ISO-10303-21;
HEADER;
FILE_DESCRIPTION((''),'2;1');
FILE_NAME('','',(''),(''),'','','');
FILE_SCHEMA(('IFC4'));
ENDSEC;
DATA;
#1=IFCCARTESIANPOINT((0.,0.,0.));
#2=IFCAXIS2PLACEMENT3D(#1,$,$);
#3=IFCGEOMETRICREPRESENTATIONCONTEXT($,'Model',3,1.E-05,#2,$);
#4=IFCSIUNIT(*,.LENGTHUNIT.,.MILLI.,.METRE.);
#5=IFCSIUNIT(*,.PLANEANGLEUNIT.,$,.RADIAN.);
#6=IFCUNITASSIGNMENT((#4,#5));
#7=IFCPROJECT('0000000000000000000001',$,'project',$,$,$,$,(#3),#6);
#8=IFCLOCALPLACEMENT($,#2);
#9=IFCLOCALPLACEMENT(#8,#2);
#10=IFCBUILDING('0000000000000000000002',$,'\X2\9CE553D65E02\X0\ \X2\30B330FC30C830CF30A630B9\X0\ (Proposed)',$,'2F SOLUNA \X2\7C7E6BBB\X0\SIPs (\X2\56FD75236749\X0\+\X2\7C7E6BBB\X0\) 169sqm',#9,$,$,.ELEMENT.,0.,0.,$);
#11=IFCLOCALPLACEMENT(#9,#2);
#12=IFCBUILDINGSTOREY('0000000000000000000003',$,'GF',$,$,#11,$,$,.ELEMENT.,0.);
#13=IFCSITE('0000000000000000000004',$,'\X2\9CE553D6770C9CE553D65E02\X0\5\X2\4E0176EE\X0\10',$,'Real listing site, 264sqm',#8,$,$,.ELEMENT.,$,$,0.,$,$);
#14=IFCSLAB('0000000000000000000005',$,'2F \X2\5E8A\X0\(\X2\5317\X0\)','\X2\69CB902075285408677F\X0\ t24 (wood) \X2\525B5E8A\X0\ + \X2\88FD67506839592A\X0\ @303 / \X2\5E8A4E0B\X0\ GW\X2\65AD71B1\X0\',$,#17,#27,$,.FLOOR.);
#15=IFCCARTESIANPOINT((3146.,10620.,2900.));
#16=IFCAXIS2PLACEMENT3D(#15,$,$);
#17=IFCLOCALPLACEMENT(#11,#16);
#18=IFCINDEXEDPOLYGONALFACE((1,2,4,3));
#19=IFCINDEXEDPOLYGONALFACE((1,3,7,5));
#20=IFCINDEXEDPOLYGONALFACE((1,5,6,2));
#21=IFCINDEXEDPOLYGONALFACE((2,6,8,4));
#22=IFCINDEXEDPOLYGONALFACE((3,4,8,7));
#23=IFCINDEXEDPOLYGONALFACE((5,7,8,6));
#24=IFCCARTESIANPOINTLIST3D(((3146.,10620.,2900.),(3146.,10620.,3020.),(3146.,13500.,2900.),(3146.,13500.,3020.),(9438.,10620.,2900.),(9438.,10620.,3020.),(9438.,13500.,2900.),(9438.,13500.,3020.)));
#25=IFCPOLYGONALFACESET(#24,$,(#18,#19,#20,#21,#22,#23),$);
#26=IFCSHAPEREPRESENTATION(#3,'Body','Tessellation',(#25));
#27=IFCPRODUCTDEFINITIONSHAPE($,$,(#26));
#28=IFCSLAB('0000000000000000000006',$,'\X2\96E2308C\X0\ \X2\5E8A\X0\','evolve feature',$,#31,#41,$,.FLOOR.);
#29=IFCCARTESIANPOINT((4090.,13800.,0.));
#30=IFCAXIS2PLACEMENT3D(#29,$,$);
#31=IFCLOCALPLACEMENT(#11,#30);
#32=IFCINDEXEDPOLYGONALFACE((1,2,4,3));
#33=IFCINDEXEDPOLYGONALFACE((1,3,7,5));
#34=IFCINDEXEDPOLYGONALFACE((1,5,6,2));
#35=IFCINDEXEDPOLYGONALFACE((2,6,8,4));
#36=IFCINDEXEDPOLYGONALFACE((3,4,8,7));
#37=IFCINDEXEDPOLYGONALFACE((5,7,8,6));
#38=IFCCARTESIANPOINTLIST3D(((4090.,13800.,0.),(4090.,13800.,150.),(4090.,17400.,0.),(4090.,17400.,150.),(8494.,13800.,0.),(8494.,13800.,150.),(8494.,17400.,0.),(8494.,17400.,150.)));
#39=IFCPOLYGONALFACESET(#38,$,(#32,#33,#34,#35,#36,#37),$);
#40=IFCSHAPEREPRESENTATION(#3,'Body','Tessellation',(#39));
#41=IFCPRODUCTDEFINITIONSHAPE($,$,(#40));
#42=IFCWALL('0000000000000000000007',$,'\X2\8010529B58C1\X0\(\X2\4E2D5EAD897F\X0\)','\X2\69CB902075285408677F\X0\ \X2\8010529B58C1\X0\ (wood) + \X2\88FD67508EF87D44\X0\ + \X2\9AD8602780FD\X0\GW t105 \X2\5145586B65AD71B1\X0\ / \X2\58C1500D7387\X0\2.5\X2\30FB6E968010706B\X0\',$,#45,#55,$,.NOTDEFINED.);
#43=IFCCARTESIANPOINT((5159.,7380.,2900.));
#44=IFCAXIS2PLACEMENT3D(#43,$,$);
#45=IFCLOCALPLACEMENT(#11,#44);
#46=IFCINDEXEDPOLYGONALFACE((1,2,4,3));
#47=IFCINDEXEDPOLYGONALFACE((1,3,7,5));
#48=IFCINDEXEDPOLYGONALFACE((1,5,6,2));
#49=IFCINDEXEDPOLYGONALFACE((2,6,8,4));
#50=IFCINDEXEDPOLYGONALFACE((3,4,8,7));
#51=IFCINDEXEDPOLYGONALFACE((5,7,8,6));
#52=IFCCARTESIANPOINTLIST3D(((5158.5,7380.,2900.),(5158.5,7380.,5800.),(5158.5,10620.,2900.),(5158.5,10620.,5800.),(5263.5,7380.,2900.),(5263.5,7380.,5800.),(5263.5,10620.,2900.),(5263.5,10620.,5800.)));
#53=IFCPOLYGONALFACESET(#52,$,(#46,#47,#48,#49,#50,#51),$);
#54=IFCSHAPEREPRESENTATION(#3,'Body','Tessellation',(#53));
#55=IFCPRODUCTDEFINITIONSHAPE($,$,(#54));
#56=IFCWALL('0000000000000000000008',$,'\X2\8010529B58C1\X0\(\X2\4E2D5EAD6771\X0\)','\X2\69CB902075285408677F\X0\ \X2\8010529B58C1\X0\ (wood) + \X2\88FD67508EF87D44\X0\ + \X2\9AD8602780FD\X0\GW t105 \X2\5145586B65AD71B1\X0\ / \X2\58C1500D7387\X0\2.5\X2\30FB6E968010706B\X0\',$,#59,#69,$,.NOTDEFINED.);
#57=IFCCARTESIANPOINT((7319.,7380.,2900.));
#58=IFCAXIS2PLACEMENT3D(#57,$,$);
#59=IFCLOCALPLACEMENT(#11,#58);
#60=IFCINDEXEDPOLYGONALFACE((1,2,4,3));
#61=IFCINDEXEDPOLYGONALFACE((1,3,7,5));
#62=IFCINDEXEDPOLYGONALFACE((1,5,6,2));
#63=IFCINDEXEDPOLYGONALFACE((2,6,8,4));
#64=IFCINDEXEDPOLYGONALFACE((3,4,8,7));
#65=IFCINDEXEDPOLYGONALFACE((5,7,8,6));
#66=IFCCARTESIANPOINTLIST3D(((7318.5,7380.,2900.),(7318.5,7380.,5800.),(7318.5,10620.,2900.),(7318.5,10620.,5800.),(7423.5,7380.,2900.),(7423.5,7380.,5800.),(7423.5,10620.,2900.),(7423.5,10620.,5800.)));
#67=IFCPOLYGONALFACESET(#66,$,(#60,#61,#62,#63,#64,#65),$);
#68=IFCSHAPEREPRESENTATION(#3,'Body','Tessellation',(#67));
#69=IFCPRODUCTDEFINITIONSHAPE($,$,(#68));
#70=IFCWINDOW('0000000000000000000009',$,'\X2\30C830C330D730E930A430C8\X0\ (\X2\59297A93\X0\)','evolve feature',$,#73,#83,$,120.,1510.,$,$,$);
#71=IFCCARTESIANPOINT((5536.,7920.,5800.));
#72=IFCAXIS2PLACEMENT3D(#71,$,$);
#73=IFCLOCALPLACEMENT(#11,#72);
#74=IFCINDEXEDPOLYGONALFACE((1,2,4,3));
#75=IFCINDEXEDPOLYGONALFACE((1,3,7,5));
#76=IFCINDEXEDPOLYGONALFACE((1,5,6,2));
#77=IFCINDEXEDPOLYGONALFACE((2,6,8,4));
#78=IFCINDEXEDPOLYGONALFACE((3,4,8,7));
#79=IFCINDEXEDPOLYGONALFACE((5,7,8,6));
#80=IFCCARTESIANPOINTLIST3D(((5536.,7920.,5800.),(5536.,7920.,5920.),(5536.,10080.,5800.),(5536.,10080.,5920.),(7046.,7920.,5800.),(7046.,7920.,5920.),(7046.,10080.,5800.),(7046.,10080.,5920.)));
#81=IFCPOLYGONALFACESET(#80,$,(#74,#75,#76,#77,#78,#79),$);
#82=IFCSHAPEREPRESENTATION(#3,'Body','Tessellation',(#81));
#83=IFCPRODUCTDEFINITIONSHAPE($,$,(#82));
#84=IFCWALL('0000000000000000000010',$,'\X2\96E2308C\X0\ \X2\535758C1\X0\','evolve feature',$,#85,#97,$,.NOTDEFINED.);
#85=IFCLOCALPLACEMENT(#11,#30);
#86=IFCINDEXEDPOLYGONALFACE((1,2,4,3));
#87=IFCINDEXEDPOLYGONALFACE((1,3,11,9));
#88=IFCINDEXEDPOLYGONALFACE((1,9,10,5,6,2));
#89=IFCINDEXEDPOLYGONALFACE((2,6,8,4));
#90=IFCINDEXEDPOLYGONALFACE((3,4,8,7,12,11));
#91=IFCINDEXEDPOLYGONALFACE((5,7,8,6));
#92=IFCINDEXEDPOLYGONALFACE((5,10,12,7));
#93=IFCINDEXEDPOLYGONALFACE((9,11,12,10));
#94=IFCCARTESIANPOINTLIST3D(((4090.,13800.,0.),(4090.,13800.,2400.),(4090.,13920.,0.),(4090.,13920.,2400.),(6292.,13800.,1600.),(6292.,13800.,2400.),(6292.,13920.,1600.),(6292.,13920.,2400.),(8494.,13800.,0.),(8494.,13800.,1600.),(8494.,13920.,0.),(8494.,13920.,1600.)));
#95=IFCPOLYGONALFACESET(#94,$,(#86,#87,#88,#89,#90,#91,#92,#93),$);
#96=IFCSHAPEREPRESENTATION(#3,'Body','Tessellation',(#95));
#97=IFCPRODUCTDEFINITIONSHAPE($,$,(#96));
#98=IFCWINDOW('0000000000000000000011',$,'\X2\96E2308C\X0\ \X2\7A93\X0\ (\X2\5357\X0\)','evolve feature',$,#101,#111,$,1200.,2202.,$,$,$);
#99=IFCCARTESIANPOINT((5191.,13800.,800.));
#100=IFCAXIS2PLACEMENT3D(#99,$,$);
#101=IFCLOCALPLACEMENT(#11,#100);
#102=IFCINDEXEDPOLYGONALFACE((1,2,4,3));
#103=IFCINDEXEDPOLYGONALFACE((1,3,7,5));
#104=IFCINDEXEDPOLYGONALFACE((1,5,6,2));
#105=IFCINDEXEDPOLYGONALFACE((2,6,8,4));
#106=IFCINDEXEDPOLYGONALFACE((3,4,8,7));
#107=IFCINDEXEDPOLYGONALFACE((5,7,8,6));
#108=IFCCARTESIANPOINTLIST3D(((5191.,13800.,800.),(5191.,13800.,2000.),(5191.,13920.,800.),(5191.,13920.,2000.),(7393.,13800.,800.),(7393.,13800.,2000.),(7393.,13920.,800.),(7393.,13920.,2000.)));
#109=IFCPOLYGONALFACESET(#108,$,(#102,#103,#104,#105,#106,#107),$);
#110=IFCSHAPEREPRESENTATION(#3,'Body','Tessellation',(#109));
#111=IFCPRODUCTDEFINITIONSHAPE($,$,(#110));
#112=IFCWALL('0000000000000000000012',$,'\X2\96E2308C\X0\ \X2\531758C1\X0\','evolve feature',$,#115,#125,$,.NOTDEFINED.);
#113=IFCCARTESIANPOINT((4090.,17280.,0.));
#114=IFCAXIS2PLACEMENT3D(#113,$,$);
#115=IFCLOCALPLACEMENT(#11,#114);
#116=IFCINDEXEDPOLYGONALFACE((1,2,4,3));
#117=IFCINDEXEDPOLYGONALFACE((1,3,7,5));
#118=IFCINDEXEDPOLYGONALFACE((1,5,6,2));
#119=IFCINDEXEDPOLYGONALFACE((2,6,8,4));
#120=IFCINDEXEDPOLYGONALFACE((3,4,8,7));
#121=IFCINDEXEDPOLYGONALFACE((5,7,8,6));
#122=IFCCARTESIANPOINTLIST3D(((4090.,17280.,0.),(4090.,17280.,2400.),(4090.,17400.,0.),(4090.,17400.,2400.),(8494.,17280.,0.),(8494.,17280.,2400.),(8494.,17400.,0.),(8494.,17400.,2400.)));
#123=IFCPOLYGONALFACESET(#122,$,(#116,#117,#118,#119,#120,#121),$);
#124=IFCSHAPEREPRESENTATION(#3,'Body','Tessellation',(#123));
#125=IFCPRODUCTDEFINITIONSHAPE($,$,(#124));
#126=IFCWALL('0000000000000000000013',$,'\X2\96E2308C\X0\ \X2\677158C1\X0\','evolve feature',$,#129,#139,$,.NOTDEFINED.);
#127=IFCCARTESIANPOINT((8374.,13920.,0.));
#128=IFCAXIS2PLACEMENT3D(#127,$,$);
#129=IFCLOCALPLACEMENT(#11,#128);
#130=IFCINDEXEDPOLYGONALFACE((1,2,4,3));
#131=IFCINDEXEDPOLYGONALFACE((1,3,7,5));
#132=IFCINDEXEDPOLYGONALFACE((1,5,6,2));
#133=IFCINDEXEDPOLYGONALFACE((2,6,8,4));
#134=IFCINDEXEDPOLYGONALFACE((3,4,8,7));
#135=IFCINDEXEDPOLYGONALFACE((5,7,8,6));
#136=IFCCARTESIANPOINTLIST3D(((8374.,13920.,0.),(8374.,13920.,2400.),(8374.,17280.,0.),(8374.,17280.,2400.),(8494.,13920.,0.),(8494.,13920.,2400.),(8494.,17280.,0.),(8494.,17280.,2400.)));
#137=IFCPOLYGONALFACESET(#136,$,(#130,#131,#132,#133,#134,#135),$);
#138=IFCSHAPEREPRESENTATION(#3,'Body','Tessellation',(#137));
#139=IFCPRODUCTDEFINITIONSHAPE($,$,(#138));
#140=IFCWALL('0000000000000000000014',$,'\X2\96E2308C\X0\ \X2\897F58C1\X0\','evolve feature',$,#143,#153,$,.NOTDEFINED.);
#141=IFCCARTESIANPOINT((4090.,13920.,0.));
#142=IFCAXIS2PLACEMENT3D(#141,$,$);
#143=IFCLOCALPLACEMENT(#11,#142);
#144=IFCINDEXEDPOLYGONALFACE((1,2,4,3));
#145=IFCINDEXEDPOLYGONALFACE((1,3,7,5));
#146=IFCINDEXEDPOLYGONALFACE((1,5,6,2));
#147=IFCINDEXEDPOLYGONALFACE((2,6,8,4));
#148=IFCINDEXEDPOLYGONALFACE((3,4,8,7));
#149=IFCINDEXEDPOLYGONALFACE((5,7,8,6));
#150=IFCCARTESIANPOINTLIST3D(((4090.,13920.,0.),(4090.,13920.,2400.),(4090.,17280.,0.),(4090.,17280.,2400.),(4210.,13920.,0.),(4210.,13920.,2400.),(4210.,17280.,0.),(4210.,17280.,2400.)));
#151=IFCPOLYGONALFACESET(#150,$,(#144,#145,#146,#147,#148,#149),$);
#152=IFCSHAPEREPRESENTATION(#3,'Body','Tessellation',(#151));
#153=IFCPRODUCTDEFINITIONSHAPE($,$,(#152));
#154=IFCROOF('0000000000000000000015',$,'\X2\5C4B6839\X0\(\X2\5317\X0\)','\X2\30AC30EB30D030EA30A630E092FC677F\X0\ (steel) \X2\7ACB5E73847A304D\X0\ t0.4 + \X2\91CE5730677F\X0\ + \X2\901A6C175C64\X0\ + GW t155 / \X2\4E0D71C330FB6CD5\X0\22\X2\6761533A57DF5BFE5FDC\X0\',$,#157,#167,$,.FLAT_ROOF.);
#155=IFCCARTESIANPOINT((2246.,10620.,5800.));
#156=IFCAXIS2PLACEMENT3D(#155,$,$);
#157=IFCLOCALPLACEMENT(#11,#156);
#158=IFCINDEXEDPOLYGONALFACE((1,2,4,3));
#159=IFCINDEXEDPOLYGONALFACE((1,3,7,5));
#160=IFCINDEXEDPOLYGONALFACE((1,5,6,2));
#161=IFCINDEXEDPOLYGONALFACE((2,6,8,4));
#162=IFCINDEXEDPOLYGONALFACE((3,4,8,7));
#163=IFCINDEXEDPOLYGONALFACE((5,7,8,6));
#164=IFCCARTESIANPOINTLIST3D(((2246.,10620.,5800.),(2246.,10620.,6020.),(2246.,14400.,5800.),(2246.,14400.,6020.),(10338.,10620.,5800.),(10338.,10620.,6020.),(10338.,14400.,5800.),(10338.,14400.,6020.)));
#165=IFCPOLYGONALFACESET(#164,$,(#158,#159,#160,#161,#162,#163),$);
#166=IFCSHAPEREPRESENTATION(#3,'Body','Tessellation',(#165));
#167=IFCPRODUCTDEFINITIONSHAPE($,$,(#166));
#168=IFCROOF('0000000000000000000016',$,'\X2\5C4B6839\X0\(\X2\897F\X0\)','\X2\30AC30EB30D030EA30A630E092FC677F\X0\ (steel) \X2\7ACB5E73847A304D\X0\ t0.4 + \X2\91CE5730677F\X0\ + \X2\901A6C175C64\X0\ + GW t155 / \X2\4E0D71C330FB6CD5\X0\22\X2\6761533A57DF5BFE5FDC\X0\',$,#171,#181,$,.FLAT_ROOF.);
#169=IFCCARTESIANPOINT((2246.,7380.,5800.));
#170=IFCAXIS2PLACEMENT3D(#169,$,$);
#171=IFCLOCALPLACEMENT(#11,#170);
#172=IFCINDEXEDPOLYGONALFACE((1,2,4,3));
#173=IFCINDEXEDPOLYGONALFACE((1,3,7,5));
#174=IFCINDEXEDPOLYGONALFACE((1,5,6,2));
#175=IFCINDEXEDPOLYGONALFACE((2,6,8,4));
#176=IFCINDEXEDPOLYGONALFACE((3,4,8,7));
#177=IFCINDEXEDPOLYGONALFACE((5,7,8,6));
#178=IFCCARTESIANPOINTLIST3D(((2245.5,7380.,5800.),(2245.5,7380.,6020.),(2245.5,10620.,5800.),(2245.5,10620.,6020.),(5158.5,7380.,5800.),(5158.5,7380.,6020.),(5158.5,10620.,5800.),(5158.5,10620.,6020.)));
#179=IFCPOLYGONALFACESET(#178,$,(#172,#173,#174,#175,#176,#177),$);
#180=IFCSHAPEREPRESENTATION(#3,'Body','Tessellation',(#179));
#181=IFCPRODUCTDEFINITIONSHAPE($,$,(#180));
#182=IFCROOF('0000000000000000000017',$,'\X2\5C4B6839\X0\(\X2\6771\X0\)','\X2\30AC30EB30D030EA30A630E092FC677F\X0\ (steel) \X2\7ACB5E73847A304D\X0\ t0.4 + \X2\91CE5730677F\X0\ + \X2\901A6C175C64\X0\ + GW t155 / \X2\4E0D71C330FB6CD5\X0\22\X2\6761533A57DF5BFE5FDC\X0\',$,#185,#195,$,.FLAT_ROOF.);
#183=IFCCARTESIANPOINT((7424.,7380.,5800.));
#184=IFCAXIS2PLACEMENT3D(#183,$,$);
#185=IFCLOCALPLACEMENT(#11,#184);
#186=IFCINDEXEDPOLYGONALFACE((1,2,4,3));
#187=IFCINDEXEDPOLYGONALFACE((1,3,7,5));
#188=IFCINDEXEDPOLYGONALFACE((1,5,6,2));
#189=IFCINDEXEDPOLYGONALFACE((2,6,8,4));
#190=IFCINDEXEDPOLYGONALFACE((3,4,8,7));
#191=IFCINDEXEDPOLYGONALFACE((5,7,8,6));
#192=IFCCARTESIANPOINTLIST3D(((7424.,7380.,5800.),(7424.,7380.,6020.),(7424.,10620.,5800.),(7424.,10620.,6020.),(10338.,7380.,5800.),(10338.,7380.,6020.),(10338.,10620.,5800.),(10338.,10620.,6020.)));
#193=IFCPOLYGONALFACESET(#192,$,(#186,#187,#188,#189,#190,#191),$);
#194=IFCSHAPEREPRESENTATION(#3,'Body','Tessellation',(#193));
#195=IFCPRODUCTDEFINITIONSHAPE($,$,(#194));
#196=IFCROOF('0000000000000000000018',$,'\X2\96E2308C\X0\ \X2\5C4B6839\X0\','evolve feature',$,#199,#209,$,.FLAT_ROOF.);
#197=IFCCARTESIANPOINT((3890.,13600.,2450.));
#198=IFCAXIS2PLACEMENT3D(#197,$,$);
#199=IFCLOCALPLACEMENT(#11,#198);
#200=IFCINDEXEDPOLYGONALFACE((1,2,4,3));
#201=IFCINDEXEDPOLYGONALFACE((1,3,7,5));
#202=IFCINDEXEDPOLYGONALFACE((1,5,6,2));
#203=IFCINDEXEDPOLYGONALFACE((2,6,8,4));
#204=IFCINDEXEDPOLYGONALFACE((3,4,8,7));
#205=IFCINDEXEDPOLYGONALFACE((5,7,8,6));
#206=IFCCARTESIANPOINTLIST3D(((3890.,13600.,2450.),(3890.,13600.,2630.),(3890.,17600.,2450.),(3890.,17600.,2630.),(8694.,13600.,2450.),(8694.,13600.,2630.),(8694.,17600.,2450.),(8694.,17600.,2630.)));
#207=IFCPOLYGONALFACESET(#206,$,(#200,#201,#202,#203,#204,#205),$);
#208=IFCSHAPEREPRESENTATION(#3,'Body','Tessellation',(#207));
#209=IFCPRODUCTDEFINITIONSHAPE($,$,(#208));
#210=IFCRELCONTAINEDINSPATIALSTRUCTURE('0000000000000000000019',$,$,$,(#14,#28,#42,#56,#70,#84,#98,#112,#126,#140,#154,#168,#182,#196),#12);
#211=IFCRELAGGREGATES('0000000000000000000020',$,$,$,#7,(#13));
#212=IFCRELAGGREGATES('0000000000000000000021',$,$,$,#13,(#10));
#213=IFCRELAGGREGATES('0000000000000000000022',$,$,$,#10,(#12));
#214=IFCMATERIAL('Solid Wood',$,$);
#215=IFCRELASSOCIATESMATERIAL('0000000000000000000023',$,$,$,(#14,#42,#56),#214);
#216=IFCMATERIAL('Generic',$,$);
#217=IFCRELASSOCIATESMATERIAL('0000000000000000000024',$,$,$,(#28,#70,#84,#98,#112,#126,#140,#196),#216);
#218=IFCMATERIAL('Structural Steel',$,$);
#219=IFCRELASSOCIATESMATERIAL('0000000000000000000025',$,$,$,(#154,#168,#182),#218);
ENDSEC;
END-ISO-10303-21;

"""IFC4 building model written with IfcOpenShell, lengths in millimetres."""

from ifc_helpers import new_model, si_unit, frame, frame_2d, origin, place, context, project, spatial, rectangle, extrude, material, element, fill, save


model = new_model("IFC4")

# Units and contexts
model_context = context("Model", 3, precision=1e-05, world=origin())
ifc_project = project(units=[si_unit("LENGTHUNIT", "METRE", prefix="MILLI"), si_unit("PLANEANGLEUNIT", "RADIAN")], contexts=[model_context])

# Site, building, storey
site_placement = place(None, origin())
site = spatial("IfcSite", under=ifc_project, at=site_placement, Name="鳥取県鳥取市5丁目10", ObjectType="Real listing site, 264sqm", CompositionType="ELEMENT", RefElevation=0.0)
building_placement = place(site_placement, origin())
building = spatial("IfcBuilding", under=site, at=building_placement, Name="鳥取市 コートハウス (Proposed)", ObjectType="2F SOLUNA 籾殻SIPs (国産杉+籾殻) 169sqm", CompositionType="ELEMENT", ElevationOfRefHeight=0.0, ElevationOfTerrain=0.0)
storey_placement = place(building_placement, origin())
storey = spatial("IfcBuildingStorey", under=building, at=storey_placement, Name="GF", CompositionType="ELEMENT", Elevation=0.0)

# Slabs
ifc_material_1 = material(Name="Solid Wood")
slab_1_placement = place(storey_placement, frame((3146.0, 10620.0, 2900.0)))
element("IfcSlab", 1, at=slab_1_placement, inside=storey, material=ifc_material_1, Name="2F 床(北)", Description="構造用合板 t24 (wood) 剛床 + 製材根太 @303 / 床下 GW断熱", PredefinedType="FLOOR", context=model_context, shape_type="SweptSolid", body=[
    extrude(rectangle(XDim=6292.0, YDim=2880.0, at=frame_2d((3146.0, 1440.0))), frame((3146.0, 10620.0, 2900.0)), (0.0, 0.0, 1.0), 120.0),
])
ifc_material_2 = material(Name="Generic")
slab_2_placement = place(storey_placement, frame((4090.0, 13800.0, 0.0)))
element("IfcSlab", 2, at=slab_2_placement, inside=storey, material=ifc_material_2, Name="離れ 床", Description="evolve feature", PredefinedType="FLOOR", context=model_context, shape_type="SweptSolid", body=[
    extrude(rectangle(XDim=4404.0, YDim=3600.0, at=frame_2d((2202.0, 1800.0))), frame((4090.0, 13800.0, 0.0)), (0.0, 0.0, 1.0), 150.0),
])

# Walls
wall_1_placement = place(storey_placement, frame((5159.0, 7380.0, 2900.0)))
element("IfcWall", 3, at=wall_1_placement, inside=storey, material=ifc_material_1, Name="耐力壁(中庭西)", Description="構造用合板 耐力壁 (wood) + 製材軸組 + 高性能GW t105 充填断熱 / 壁倍率2.5・準耐火", PredefinedType="NOTDEFINED", context=model_context, shape_type="SweptSolid", body=[
    extrude(rectangle(XDim=105.0, YDim=3240.0, at=frame_2d((52.0, 1620.0))), frame((5159.0, 7380.0, 2900.0)), (0.0, 0.0, 1.0), 2900.0),
])
wall_2_placement = place(storey_placement, frame((7319.0, 7380.0, 2900.0)))
element("IfcWall", 4, at=wall_2_placement, inside=storey, material=ifc_material_1, Name="耐力壁(中庭東)", Description="構造用合板 耐力壁 (wood) + 製材軸組 + 高性能GW t105 充填断熱 / 壁倍率2.5・準耐火", PredefinedType="NOTDEFINED", context=model_context, shape_type="SweptSolid", body=[
    extrude(rectangle(XDim=105.0, YDim=3240.0, at=frame_2d((52.0, 1620.0))), frame((7319.0, 7380.0, 2900.0)), (0.0, 0.0, 1.0), 2900.0),
])

# Window
window_1_placement = place(storey_placement, frame((5536.0, 7920.0, 5800.0)))
element("IfcWindow", 5, at=window_1_placement, inside=storey, material=ifc_material_2, Name="トップライト (天窓)", Description="evolve feature", OverallHeight=120.0, OverallWidth=1510.0, context=model_context, shape_type="SweptSolid", body=[
    extrude(rectangle(XDim=1510.0, YDim=2160.0, at=frame_2d((755.0, 1080.0))), frame((5536.0, 7920.0, 5800.0)), (0.0, 0.0, 1.0), 120.0),
])

# Wall, opening, window
wall_3_placement = place(storey_placement, frame((4090.0, 13800.0, 0.0)))
wall_3 = element("IfcWall", 6, at=wall_3_placement, inside=storey, material=ifc_material_2, Name="離れ 南壁", Description="evolve feature", PredefinedType="NOTDEFINED", context=model_context, shape_type="SweptSolid", body=[
    extrude(rectangle(XDim=4404.0, YDim=120.0, at=frame_2d((2202.0, 60.0))), frame((4090.0, 13800.0, 0.0)), (0.0, 0.0, 1.0), 2400.0),
])
opening_1_placement = place(storey_placement, frame((5191.0, 13800.0, 800.0)))
opening_1 = element("IfcOpeningElement", 7, at=opening_1_placement, cuts=wall_3, PredefinedType="NOTDEFINED", context=model_context, shape_type="SweptSolid", body=[
    extrude(rectangle(XDim=2202.0, YDim=120.0, at=frame_2d((1101.0, 60.0))), frame((5191.0, 13800.0, 800.0)), (0.0, 0.0, 1.0), 1200.0),
])
window_2_placement = place(storey_placement, frame((5191.0, 13800.0, 800.0)))
window_2 = element("IfcWindow", 8, at=window_2_placement, inside=storey, material=ifc_material_2, Name="離れ 窓 (南)", Description="evolve feature", OverallHeight=1200.0, OverallWidth=2202.0, context=model_context, shape_type="SweptSolid", body=[
    extrude(rectangle(XDim=2202.0, YDim=120.0, at=frame_2d((1101.0, 60.0))), frame((5191.0, 13800.0, 800.0)), (0.0, 0.0, 1.0), 1200.0),
])
fill(opening_1, window_2)

# Walls
wall_4_placement = place(storey_placement, frame((4090.0, 17280.0, 0.0)))
element("IfcWall", 9, at=wall_4_placement, inside=storey, material=ifc_material_2, Name="離れ 北壁", Description="evolve feature", PredefinedType="NOTDEFINED", context=model_context, shape_type="SweptSolid", body=[
    extrude(rectangle(XDim=4404.0, YDim=120.0, at=frame_2d((2202.0, 60.0))), frame((4090.0, 17280.0, 0.0)), (0.0, 0.0, 1.0), 2400.0),
])
wall_5_placement = place(storey_placement, frame((8374.0, 13920.0, 0.0)))
element("IfcWall", 10, at=wall_5_placement, inside=storey, material=ifc_material_2, Name="離れ 東壁", Description="evolve feature", PredefinedType="NOTDEFINED", context=model_context, shape_type="SweptSolid", body=[
    extrude(rectangle(XDim=120.0, YDim=3360.0, at=frame_2d((60.0, 1680.0))), frame((8374.0, 13920.0, 0.0)), (0.0, 0.0, 1.0), 2400.0),
])
wall_6_placement = place(storey_placement, frame((4090.0, 13920.0, 0.0)))
element("IfcWall", 11, at=wall_6_placement, inside=storey, material=ifc_material_2, Name="離れ 西壁", Description="evolve feature", PredefinedType="NOTDEFINED", context=model_context, shape_type="SweptSolid", body=[
    extrude(rectangle(XDim=120.0, YDim=3360.0, at=frame_2d((60.0, 1680.0))), frame((4090.0, 13920.0, 0.0)), (0.0, 0.0, 1.0), 2400.0),
])

# Roofs
ifc_material_3 = material(Name="Structural Steel")
for number, where, name in (
    (12, (2246.0, 10620.0, 5800.0), "屋根(北)"),
):
    element("IfcRoof", number, at=place(storey_placement, frame(where)), inside=storey, material=ifc_material_3, Name=name, Description="ガルバリウム鋼板 (steel) 立平葺き t0.4 + 野地板 + 通気層 + GW t155 / 不燃・法22条区域対応", PredefinedType="FLAT_ROOF", context=model_context, shape_type="SweptSolid", body=[
        extrude(rectangle(XDim=8092.0, YDim=3780.0, at=frame_2d((4046.0, 1890.0))), frame((2246.0, 10620.0, 5800.0)), (0.0, 0.0, 1.0), 220.0),
    ])
roof_1_placement = place(storey_placement, frame((2246.0, 7380.0, 5800.0)))
element("IfcRoof", 13, at=roof_1_placement, inside=storey, material=ifc_material_3, Name="屋根(西)", Description="ガルバリウム鋼板 (steel) 立平葺き t0.4 + 野地板 + 通気層 + GW t155 / 不燃・法22条区域対応", PredefinedType="FLAT_ROOF", context=model_context, shape_type="SweptSolid", body=[
    extrude(rectangle(XDim=2913.0, YDim=3240.0, at=frame_2d((1456.0, 1620.0))), frame((2246.0, 7380.0, 5800.0)), (0.0, 0.0, 1.0), 220.0),
])
roof_2_placement = place(storey_placement, frame((7424.0, 7380.0, 5800.0)))
element("IfcRoof", 14, at=roof_2_placement, inside=storey, material=ifc_material_3, Name="屋根(東)", Description="ガルバリウム鋼板 (steel) 立平葺き t0.4 + 野地板 + 通気層 + GW t155 / 不燃・法22条区域対応", PredefinedType="FLAT_ROOF", context=model_context, shape_type="SweptSolid", body=[
    extrude(rectangle(XDim=2914.0, YDim=3240.0, at=frame_2d((1457.0, 1620.0))), frame((7424.0, 7380.0, 5800.0)), (0.0, 0.0, 1.0), 220.0),
])
roof_3_placement = place(storey_placement, frame((3890.0, 13600.0, 2450.0)))
element("IfcRoof", 15, at=roof_3_placement, inside=storey, material=ifc_material_2, Name="離れ 屋根", Description="evolve feature", PredefinedType="FLAT_ROOF", context=model_context, shape_type="SweptSolid", body=[
    extrude(rectangle(XDim=4804.0, YDim=4000.0, at=frame_2d((2402.0, 2000.0))), frame((3890.0, 13600.0, 2450.0)), (0.0, 0.0, 1.0), 180.0),
])

save(model, "model.ifc")
